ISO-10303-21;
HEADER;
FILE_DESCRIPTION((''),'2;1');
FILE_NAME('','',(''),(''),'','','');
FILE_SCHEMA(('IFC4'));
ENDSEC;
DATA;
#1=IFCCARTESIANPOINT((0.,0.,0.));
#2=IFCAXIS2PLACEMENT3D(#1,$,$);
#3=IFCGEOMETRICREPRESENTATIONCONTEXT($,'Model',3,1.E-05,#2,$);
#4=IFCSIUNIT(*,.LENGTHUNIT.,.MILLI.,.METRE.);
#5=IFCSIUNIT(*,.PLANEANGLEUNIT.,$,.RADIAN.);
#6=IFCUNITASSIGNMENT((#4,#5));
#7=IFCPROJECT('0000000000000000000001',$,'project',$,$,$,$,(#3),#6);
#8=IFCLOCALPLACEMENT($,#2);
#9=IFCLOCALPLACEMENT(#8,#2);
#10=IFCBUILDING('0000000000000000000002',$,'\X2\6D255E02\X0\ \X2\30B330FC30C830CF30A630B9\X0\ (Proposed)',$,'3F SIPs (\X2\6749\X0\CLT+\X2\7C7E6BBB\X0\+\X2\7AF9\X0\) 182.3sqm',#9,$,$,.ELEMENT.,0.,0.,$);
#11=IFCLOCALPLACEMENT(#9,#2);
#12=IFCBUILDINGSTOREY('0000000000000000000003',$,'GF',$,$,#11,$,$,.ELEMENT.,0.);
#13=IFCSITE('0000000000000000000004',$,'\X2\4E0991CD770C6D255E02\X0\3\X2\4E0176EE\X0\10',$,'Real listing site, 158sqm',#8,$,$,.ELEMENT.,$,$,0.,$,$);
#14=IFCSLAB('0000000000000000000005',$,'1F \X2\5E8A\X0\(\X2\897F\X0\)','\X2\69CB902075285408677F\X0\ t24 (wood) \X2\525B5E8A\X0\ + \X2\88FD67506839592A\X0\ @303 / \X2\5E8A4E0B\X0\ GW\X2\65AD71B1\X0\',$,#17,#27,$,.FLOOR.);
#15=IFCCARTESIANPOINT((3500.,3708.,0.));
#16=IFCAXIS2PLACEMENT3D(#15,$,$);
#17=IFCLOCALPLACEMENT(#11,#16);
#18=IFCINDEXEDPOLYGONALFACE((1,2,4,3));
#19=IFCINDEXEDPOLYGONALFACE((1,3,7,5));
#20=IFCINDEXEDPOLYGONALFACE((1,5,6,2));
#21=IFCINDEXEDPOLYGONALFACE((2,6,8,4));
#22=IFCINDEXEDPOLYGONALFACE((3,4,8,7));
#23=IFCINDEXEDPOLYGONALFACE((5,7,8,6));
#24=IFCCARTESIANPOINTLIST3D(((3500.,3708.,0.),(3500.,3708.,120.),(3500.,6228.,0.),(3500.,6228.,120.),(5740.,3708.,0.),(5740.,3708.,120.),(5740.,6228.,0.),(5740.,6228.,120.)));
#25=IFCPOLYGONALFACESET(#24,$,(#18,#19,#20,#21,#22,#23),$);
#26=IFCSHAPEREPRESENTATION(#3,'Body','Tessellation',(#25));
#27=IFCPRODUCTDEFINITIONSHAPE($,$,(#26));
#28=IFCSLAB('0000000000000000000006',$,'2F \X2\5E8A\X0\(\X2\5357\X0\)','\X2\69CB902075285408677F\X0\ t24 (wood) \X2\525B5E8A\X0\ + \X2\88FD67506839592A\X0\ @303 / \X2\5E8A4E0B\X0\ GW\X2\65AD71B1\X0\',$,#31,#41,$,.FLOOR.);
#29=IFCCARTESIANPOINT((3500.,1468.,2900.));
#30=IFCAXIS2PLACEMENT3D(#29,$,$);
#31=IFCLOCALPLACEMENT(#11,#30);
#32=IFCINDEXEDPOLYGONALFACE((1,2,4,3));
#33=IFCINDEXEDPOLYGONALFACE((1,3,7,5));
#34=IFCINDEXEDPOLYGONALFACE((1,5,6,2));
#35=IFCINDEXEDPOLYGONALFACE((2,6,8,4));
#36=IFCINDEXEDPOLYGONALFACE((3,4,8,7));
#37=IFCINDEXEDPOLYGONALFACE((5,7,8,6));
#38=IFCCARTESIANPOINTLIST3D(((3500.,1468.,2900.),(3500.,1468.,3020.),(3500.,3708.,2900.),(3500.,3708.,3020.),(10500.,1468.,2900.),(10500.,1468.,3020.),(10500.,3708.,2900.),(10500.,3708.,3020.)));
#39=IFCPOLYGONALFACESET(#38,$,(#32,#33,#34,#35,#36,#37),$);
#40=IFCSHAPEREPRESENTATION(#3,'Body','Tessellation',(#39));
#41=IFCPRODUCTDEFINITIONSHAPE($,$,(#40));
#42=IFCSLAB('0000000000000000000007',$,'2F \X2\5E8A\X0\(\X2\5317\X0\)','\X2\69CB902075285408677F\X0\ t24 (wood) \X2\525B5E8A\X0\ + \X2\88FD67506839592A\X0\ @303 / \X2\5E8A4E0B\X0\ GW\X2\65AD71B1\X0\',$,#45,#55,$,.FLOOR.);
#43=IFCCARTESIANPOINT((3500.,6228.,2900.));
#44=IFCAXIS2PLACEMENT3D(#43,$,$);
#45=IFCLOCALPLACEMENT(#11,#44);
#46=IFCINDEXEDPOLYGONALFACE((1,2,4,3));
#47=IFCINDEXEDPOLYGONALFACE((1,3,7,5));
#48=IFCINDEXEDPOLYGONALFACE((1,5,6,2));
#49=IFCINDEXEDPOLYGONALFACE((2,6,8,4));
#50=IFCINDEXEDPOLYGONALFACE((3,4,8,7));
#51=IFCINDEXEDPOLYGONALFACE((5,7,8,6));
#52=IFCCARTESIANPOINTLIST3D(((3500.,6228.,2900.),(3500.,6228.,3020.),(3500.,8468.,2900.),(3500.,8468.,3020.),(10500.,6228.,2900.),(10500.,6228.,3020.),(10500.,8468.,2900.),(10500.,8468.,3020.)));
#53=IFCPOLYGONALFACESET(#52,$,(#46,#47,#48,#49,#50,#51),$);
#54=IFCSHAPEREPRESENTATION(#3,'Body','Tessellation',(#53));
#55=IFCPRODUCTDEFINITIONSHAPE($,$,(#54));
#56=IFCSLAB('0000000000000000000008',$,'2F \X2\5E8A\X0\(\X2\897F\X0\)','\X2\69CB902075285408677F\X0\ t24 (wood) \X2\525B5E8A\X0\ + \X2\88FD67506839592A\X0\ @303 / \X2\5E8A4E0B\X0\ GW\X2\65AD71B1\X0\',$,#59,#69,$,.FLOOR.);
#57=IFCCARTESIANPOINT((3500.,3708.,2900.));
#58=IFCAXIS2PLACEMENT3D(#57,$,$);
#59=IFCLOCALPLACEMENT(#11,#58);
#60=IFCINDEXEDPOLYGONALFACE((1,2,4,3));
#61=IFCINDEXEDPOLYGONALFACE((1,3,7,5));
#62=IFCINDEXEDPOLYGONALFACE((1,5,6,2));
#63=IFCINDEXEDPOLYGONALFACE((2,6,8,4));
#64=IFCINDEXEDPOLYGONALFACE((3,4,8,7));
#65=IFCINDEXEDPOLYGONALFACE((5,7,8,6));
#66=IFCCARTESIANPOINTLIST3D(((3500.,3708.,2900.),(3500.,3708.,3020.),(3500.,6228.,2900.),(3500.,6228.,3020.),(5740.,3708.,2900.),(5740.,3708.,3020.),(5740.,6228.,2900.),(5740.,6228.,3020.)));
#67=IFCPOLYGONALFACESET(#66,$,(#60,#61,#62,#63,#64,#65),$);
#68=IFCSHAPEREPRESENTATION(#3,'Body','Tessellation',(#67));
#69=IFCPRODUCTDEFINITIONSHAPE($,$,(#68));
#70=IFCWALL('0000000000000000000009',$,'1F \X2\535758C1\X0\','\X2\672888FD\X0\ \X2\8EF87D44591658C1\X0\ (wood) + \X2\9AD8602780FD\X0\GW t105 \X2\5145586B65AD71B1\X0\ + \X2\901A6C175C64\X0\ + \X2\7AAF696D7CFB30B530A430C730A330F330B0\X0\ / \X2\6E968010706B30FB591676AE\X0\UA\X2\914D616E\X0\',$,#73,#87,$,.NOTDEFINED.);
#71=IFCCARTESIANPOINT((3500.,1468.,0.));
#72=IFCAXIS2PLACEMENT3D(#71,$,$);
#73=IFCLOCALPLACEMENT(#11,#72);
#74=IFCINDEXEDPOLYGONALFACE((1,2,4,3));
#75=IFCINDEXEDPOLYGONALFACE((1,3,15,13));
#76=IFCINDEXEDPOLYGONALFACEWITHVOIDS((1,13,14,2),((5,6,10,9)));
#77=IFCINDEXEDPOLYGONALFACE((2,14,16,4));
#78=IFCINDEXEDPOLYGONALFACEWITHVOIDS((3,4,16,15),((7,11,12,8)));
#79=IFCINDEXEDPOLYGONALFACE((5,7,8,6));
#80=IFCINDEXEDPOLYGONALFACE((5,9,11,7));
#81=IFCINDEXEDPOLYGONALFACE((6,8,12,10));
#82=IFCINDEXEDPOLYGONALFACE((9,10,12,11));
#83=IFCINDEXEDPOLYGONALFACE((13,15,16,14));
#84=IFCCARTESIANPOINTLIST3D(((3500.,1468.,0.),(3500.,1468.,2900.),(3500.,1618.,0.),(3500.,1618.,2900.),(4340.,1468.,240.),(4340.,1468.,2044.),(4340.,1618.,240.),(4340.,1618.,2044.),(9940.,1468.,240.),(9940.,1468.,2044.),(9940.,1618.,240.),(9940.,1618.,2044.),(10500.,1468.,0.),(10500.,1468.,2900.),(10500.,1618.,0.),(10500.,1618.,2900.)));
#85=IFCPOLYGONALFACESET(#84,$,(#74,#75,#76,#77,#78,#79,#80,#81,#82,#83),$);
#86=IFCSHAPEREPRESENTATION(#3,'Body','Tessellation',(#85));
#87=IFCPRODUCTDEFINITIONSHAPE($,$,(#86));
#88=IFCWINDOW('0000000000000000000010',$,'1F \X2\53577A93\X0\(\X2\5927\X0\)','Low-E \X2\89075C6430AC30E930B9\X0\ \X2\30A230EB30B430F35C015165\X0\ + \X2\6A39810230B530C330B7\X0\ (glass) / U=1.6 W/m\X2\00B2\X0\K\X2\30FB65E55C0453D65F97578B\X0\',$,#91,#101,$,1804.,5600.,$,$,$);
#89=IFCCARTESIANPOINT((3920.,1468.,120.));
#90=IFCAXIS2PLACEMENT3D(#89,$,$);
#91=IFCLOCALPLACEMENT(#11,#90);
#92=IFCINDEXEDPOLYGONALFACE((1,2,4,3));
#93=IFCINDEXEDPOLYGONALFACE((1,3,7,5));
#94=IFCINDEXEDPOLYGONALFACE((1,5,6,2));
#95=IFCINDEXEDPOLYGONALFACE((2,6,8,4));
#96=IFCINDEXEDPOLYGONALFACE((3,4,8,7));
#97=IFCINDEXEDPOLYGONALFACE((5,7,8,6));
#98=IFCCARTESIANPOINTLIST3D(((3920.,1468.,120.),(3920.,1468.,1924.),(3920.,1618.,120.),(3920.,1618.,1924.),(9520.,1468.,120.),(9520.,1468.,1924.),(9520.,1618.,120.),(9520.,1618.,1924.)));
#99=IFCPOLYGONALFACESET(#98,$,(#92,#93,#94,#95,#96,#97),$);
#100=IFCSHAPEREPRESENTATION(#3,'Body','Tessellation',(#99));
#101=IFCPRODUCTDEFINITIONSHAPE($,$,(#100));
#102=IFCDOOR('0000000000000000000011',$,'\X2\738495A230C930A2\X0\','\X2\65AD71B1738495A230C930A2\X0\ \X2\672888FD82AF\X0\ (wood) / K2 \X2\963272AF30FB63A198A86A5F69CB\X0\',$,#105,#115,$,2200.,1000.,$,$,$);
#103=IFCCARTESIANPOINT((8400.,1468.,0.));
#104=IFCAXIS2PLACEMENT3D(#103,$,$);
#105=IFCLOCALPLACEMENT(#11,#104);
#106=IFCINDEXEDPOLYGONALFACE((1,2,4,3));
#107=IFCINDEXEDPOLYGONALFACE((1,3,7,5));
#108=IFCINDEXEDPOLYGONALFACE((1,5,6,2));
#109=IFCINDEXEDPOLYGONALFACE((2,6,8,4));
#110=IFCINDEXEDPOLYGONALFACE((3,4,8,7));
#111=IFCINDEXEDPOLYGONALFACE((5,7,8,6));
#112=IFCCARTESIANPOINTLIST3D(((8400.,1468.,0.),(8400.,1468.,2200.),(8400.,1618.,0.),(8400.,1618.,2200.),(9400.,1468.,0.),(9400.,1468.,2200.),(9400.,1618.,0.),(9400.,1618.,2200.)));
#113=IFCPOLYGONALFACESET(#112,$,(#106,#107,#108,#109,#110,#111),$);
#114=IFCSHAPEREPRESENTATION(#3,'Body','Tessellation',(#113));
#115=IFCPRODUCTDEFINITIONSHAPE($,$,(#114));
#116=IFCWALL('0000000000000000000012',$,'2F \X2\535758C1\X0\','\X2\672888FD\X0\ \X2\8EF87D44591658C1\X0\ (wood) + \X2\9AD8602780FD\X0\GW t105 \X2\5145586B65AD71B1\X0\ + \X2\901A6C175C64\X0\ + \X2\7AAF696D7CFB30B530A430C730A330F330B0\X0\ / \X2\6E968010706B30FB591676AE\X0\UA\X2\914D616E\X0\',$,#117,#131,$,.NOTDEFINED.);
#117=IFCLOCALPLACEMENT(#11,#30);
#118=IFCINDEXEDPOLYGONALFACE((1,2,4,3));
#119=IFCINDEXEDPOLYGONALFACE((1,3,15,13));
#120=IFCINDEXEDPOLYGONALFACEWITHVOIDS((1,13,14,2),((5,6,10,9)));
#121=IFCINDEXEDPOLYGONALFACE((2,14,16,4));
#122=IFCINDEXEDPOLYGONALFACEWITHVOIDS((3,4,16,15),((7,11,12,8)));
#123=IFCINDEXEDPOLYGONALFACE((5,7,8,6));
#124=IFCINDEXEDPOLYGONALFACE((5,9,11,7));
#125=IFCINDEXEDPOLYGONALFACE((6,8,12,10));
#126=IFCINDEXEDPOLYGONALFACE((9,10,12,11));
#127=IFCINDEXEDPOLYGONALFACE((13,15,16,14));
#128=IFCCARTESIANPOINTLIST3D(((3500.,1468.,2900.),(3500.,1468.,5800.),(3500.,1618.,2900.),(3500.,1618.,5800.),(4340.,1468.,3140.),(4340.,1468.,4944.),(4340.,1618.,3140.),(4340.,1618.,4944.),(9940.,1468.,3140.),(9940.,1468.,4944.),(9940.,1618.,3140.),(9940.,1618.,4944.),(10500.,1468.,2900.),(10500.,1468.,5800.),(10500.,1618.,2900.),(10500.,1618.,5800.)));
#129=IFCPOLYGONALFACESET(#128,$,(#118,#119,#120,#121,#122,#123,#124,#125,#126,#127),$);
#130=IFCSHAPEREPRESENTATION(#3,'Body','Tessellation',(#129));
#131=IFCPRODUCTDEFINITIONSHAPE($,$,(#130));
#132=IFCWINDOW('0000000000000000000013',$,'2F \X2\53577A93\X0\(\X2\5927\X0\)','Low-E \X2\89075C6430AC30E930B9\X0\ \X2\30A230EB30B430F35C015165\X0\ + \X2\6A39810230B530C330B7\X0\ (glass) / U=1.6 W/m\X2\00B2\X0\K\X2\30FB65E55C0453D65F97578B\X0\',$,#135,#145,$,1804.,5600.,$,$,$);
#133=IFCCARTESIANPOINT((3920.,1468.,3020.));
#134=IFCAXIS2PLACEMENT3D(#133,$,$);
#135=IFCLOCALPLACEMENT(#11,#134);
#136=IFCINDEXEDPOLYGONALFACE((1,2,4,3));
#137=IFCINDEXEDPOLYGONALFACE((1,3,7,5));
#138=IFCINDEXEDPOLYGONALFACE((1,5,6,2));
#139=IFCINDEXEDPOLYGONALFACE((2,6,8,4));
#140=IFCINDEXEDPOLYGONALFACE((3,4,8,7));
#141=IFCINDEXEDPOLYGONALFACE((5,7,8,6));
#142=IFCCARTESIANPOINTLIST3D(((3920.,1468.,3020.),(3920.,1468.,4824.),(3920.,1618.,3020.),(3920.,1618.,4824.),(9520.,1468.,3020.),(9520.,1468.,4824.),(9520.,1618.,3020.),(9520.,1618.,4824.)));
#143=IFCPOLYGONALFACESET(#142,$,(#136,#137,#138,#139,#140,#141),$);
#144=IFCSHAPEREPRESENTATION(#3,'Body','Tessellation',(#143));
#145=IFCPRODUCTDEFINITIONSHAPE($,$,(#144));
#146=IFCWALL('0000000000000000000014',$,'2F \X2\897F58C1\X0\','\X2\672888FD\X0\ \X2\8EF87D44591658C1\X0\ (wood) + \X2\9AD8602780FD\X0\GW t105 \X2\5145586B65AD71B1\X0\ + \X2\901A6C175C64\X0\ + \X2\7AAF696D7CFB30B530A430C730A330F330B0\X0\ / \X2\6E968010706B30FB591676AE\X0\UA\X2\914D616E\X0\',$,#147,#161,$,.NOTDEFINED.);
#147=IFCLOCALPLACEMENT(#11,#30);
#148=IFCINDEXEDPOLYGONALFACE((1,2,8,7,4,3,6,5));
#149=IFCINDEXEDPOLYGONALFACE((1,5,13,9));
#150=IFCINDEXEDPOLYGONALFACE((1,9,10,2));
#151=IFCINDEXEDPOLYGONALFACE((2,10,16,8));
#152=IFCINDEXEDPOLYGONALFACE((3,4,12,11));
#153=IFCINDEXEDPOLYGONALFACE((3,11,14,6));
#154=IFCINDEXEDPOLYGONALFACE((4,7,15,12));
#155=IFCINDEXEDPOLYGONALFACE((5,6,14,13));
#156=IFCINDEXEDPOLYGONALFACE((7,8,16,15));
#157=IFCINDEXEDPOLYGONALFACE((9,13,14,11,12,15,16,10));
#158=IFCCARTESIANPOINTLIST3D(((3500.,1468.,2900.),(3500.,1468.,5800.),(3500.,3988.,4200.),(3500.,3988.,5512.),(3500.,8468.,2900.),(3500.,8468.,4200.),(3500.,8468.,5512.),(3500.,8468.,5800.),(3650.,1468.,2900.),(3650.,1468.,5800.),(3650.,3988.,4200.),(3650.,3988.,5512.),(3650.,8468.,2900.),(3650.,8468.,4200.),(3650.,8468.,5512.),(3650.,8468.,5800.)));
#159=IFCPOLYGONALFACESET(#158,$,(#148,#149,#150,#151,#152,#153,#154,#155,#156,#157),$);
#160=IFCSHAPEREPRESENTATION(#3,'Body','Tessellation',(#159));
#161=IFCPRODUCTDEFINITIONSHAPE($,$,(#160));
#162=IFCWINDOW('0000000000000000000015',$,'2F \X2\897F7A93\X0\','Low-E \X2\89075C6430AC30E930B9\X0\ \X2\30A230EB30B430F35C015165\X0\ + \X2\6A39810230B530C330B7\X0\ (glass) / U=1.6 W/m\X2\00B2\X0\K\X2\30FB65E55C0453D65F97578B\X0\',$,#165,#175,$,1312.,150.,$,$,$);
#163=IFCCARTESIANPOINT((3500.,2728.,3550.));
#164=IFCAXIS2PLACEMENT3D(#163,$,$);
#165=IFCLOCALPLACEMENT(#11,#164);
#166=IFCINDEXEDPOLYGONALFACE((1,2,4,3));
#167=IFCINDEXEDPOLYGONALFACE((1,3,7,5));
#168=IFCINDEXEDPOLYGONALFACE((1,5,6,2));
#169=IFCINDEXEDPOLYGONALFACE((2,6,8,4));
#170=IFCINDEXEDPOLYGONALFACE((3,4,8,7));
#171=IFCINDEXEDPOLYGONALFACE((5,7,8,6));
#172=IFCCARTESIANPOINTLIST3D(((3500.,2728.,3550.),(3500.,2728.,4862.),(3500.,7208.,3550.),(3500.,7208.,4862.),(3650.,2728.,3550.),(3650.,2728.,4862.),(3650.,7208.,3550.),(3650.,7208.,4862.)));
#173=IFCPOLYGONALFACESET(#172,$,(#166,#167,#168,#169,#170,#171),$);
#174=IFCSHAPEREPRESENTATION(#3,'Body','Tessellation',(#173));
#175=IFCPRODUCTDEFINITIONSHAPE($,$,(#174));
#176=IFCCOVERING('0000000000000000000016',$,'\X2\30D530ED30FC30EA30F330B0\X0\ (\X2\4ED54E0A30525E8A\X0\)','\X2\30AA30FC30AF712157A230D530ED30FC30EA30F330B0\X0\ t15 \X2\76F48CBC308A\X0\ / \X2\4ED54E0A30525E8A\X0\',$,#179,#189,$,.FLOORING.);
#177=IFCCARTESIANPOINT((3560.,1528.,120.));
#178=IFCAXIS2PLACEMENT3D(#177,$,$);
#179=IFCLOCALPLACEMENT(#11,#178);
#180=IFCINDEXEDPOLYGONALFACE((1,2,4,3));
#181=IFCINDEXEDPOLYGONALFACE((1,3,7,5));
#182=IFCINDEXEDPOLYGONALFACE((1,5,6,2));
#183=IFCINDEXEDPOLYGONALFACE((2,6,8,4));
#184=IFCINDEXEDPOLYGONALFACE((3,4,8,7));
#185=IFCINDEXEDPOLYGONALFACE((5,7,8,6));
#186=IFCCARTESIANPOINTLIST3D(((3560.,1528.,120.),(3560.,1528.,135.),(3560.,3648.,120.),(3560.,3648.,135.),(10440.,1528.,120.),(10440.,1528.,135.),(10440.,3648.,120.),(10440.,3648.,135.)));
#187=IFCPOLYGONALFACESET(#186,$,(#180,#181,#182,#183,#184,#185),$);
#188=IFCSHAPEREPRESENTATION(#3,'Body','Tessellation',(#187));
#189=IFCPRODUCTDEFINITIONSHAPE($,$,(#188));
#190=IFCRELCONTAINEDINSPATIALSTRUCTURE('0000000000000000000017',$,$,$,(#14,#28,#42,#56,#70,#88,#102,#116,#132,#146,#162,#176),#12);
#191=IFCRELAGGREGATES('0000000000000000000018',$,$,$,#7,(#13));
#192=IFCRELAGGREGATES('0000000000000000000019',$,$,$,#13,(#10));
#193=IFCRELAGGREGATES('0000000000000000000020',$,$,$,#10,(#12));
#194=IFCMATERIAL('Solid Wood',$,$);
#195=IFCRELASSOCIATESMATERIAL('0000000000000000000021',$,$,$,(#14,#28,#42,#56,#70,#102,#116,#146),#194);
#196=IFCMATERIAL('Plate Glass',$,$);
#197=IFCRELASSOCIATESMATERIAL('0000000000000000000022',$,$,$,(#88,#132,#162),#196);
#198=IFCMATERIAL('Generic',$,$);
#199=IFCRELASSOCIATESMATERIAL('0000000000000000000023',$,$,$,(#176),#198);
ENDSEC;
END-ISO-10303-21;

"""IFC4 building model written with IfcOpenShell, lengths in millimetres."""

from ifc_helpers import new_model, si_unit, frame, frame_2d, origin, place, context, project, spatial, rectangle, extrude, material, element, fill, save


model = new_model("IFC4")

# Units and contexts
model_context = context("Model", 3, precision=1e-05, world=origin())
ifc_project = project(units=[si_unit("LENGTHUNIT", "METRE", prefix="MILLI"), si_unit("PLANEANGLEUNIT", "RADIAN")], contexts=[model_context])

# Site, building, storey
site_placement = place(None, origin())
site = spatial("IfcSite", under=ifc_project, at=site_placement, Name="三重県津市3丁目10", ObjectType="Real listing site, 158sqm", CompositionType="ELEMENT", RefElevation=0.0)
building_placement = place(site_placement, origin())
building = spatial("IfcBuilding", under=site, at=building_placement, Name="津市 コートハウス (Proposed)", ObjectType="3F SIPs (杉CLT+籾殻+竹) 182.3sqm", CompositionType="ELEMENT", ElevationOfRefHeight=0.0, ElevationOfTerrain=0.0)
storey_placement = place(building_placement, origin())
storey = spatial("IfcBuildingStorey", under=building, at=storey_placement, Name="GF", CompositionType="ELEMENT", Elevation=0.0)

# Slabs
ifc_material_1 = material(Name="Solid Wood")
slab_1_placement = place(storey_placement, frame((3500.0, 3708.0, 0.0)))
element("IfcSlab", 1, at=slab_1_placement, inside=storey, material=ifc_material_1, Name="1F 床(西)", Description="構造用合板 t24 (wood) 剛床 + 製材根太 @303 / 床下 GW断熱", PredefinedType="FLOOR", context=model_context, shape_type="SweptSolid", body=[
    extrude(rectangle(XDim=2240.0, YDim=2520.0, at=frame_2d((1120.0, 1260.0))), frame((3500.0, 3708.0, 0.0)), (0.0, 0.0, 1.0), 120.0),
])
slab_2_placement = place(storey_placement, frame((3500.0, 1468.0, 2900.0)))
element("IfcSlab", 2, at=slab_2_placement, inside=storey, material=ifc_material_1, Name="2F 床(南)", Description="構造用合板 t24 (wood) 剛床 + 製材根太 @303 / 床下 GW断熱", PredefinedType="FLOOR", context=model_context, shape_type="SweptSolid", body=[
    extrude(rectangle(XDim=7000.0, YDim=2240.0, at=frame_2d((3500.0, 1120.0))), frame((3500.0, 1468.0, 2900.0)), (0.0, 0.0, 1.0), 120.0),
])
slab_3_placement = place(storey_placement, frame((3500.0, 6228.0, 2900.0)))
element("IfcSlab", 3, at=slab_3_placement, inside=storey, material=ifc_material_1, Name="2F 床(北)", Description="構造用合板 t24 (wood) 剛床 + 製材根太 @303 / 床下 GW断熱", PredefinedType="FLOOR", context=model_context, shape_type="SweptSolid", body=[
    extrude(rectangle(XDim=7000.0, YDim=2240.0, at=frame_2d((3500.0, 1120.0))), frame((3500.0, 6228.0, 2900.0)), (0.0, 0.0, 1.0), 120.0),
])
slab_4_placement = place(storey_placement, frame((3500.0, 3708.0, 2900.0)))
element("IfcSlab", 4, at=slab_4_placement, inside=storey, material=ifc_material_1, Name="2F 床(西)", Description="構造用合板 t24 (wood) 剛床 + 製材根太 @303 / 床下 GW断熱", PredefinedType="FLOOR", context=model_context, shape_type="SweptSolid", body=[
    extrude(rectangle(XDim=2240.0, YDim=2520.0, at=frame_2d((1120.0, 1260.0))), frame((3500.0, 3708.0, 2900.0)), (0.0, 0.0, 1.0), 120.0),
])

# Wall, openings, window, door
wall_1_placement = place(storey_placement, frame((3500.0, 1468.0, 0.0)))
wall_1 = element("IfcWall", 5, at=wall_1_placement, inside=storey, material=ifc_material_1, Name="1F 南壁", Description="木製 軸組外壁 (wood) + 高性能GW t105 充填断熱 + 通気層 + 窯業系サイディング / 準耐火・外皮UA配慮", PredefinedType="NOTDEFINED", context=model_context, shape_type="SweptSolid", body=[
    extrude(rectangle(XDim=7000.0, YDim=150.0, at=frame_2d((3500.0, 75.0))), frame((3500.0, 1468.0, 0.0)), (0.0, 0.0, 1.0), 2900.0),
])
opening_1_placement = place(storey_placement, frame((3920.0, 1468.0, 120.0)))
opening_1 = element("IfcOpeningElement", 6, at=opening_1_placement, cuts=wall_1, PredefinedType="NOTDEFINED", context=model_context, shape_type="SweptSolid", body=[
    extrude(rectangle(XDim=5600.0, YDim=150.0, at=frame_2d((2800.0, 75.0))), frame((3920.0, 1468.0, 120.0)), (0.0, 0.0, 1.0), 1804.0),
])
opening_2_placement = place(storey_placement, frame((8400.0, 1468.0, 0.0)))
opening_2 = element("IfcOpeningElement", 7, at=opening_2_placement, cuts=wall_1, PredefinedType="NOTDEFINED", context=model_context, shape_type="SweptSolid", body=[
    extrude(rectangle(XDim=1000.0, YDim=150.0, at=frame_2d((500.0, 75.0))), frame((8400.0, 1468.0, 0.0)), (0.0, 0.0, 1.0), 2200.0),
])
ifc_material_2 = material(Name="Plate Glass")
window_1_placement = place(storey_placement, frame((3920.0, 1468.0, 120.0)))
window_1 = element("IfcWindow", 8, at=window_1_placement, inside=storey, material=ifc_material_2, Name="1F 南窓(大)", Description="Low-E 複層ガラス アルゴン封入 + 樹脂サッシ (glass) / U=1.6 W/m²K・日射取得型", OverallHeight=1804.0, OverallWidth=5600.0, context=model_context, shape_type="SweptSolid", body=[
    extrude(rectangle(XDim=5600.0, YDim=150.0, at=frame_2d((2800.0, 75.0))), frame((3920.0, 1468.0, 120.0)), (0.0, 0.0, 1.0), 1804.0),
])
fill(opening_1, window_1)
door_placement = place(storey_placement, frame((8400.0, 1468.0, 0.0)))
door = element("IfcDoor", 9, at=door_placement, inside=storey, material=ifc_material_1, Name="玄関ドア", Description="断熱玄関ドア 木製芯 (wood) / K2 防犯・採風機構", OverallHeight=2200.0, OverallWidth=1000.0, context=model_context, shape_type="SweptSolid", body=[
    extrude(rectangle(XDim=1000.0, YDim=150.0, at=frame_2d((500.0, 75.0))), frame((8400.0, 1468.0, 0.0)), (0.0, 0.0, 1.0), 2200.0),
])
fill(opening_2, door)

# Wall, opening, window
wall_2_placement = place(storey_placement, frame((3500.0, 1468.0, 2900.0)))
wall_2 = element("IfcWall", 10, at=wall_2_placement, inside=storey, material=ifc_material_1, Name="2F 南壁", Description="木製 軸組外壁 (wood) + 高性能GW t105 充填断熱 + 通気層 + 窯業系サイディング / 準耐火・外皮UA配慮", PredefinedType="NOTDEFINED", context=model_context, shape_type="SweptSolid", body=[
    extrude(rectangle(XDim=7000.0, YDim=150.0, at=frame_2d((3500.0, 75.0))), frame((3500.0, 1468.0, 2900.0)), (0.0, 0.0, 1.0), 2900.0),
])
opening_3_placement = place(storey_placement, frame((3920.0, 1468.0, 3020.0)))
opening_3 = element("IfcOpeningElement", 11, at=opening_3_placement, cuts=wall_2, PredefinedType="NOTDEFINED", context=model_context, shape_type="SweptSolid", body=[
    extrude(rectangle(XDim=5600.0, YDim=150.0, at=frame_2d((2800.0, 75.0))), frame((3920.0, 1468.0, 3020.0)), (0.0, 0.0, 1.0), 1804.0),
])
window_2_placement = place(storey_placement, frame((3920.0, 1468.0, 3020.0)))
window_2 = element("IfcWindow", 12, at=window_2_placement, inside=storey, material=ifc_material_2, Name="2F 南窓(大)", Description="Low-E 複層ガラス アルゴン封入 + 樹脂サッシ (glass) / U=1.6 W/m²K・日射取得型", OverallHeight=1804.0, OverallWidth=5600.0, context=model_context, shape_type="SweptSolid", body=[
    extrude(rectangle(XDim=5600.0, YDim=150.0, at=frame_2d((2800.0, 75.0))), frame((3920.0, 1468.0, 3020.0)), (0.0, 0.0, 1.0), 1804.0),
])
fill(opening_3, window_2)

# Wall, opening, window
wall_3_placement = place(storey_placement, frame((3500.0, 1468.0, 2900.0)))
wall_3 = element("IfcWall", 13, at=wall_3_placement, inside=storey, material=ifc_material_1, Name="2F 西壁", Description="木製 軸組外壁 (wood) + 高性能GW t105 充填断熱 + 通気層 + 窯業系サイディング / 準耐火・外皮UA配慮", PredefinedType="NOTDEFINED", context=model_context, shape_type="SweptSolid", body=[
    extrude(rectangle(XDim=150.0, YDim=7000.0, at=frame_2d((75.0, 3500.0))), frame((3500.0, 1468.0, 2900.0)), (0.0, 0.0, 1.0), 2900.0),
])
opening_4_placement = place(storey_placement, frame((3500.0, 2728.0, 3550.0)))
opening_4 = element("IfcOpeningElement", 14, at=opening_4_placement, cuts=wall_3, PredefinedType="NOTDEFINED", context=model_context, shape_type="SweptSolid", body=[
    extrude(rectangle(XDim=150.0, YDim=4480.0, at=frame_2d((75.0, 2240.0))), frame((3500.0, 2728.0, 3550.0)), (0.0, 0.0, 1.0), 1312.0),
])
window_3_placement = place(storey_placement, frame((3500.0, 2728.0, 3550.0)))
window_3 = element("IfcWindow", 15, at=window_3_placement, inside=storey, material=ifc_material_2, Name="2F 西窓", Description="Low-E 複層ガラス アルゴン封入 + 樹脂サッシ (glass) / U=1.6 W/m²K・日射取得型", OverallHeight=1312.0, OverallWidth=150.0, context=model_context, shape_type="SweptSolid", body=[
    extrude(rectangle(XDim=150.0, YDim=4480.0, at=frame_2d((75.0, 2240.0))), frame((3500.0, 2728.0, 3550.0)), (0.0, 0.0, 1.0), 1312.0),
])
fill(opening_4, window_3)

# Covering
ifc_material_3 = material(Name="Generic")
covering_1_placement = place(storey_placement, frame((3560.0, 1528.0, 120.0)))
element("IfcCovering", 16, at=covering_1_placement, inside=storey, material=ifc_material_3, Name="フローリング (仕上げ床)", Description="オーク無垢フローリング t15 直貼り / 仕上げ床", PredefinedType="FLOORING", context=model_context, shape_type="SweptSolid", body=[
    extrude(rectangle(XDim=6880.0, YDim=2120.0, at=frame_2d((3440.0, 1060.0))), frame((3560.0, 1528.0, 120.0)), (0.0, 0.0, 1.0), 15.0),
])

save(model, "model.ifc")
